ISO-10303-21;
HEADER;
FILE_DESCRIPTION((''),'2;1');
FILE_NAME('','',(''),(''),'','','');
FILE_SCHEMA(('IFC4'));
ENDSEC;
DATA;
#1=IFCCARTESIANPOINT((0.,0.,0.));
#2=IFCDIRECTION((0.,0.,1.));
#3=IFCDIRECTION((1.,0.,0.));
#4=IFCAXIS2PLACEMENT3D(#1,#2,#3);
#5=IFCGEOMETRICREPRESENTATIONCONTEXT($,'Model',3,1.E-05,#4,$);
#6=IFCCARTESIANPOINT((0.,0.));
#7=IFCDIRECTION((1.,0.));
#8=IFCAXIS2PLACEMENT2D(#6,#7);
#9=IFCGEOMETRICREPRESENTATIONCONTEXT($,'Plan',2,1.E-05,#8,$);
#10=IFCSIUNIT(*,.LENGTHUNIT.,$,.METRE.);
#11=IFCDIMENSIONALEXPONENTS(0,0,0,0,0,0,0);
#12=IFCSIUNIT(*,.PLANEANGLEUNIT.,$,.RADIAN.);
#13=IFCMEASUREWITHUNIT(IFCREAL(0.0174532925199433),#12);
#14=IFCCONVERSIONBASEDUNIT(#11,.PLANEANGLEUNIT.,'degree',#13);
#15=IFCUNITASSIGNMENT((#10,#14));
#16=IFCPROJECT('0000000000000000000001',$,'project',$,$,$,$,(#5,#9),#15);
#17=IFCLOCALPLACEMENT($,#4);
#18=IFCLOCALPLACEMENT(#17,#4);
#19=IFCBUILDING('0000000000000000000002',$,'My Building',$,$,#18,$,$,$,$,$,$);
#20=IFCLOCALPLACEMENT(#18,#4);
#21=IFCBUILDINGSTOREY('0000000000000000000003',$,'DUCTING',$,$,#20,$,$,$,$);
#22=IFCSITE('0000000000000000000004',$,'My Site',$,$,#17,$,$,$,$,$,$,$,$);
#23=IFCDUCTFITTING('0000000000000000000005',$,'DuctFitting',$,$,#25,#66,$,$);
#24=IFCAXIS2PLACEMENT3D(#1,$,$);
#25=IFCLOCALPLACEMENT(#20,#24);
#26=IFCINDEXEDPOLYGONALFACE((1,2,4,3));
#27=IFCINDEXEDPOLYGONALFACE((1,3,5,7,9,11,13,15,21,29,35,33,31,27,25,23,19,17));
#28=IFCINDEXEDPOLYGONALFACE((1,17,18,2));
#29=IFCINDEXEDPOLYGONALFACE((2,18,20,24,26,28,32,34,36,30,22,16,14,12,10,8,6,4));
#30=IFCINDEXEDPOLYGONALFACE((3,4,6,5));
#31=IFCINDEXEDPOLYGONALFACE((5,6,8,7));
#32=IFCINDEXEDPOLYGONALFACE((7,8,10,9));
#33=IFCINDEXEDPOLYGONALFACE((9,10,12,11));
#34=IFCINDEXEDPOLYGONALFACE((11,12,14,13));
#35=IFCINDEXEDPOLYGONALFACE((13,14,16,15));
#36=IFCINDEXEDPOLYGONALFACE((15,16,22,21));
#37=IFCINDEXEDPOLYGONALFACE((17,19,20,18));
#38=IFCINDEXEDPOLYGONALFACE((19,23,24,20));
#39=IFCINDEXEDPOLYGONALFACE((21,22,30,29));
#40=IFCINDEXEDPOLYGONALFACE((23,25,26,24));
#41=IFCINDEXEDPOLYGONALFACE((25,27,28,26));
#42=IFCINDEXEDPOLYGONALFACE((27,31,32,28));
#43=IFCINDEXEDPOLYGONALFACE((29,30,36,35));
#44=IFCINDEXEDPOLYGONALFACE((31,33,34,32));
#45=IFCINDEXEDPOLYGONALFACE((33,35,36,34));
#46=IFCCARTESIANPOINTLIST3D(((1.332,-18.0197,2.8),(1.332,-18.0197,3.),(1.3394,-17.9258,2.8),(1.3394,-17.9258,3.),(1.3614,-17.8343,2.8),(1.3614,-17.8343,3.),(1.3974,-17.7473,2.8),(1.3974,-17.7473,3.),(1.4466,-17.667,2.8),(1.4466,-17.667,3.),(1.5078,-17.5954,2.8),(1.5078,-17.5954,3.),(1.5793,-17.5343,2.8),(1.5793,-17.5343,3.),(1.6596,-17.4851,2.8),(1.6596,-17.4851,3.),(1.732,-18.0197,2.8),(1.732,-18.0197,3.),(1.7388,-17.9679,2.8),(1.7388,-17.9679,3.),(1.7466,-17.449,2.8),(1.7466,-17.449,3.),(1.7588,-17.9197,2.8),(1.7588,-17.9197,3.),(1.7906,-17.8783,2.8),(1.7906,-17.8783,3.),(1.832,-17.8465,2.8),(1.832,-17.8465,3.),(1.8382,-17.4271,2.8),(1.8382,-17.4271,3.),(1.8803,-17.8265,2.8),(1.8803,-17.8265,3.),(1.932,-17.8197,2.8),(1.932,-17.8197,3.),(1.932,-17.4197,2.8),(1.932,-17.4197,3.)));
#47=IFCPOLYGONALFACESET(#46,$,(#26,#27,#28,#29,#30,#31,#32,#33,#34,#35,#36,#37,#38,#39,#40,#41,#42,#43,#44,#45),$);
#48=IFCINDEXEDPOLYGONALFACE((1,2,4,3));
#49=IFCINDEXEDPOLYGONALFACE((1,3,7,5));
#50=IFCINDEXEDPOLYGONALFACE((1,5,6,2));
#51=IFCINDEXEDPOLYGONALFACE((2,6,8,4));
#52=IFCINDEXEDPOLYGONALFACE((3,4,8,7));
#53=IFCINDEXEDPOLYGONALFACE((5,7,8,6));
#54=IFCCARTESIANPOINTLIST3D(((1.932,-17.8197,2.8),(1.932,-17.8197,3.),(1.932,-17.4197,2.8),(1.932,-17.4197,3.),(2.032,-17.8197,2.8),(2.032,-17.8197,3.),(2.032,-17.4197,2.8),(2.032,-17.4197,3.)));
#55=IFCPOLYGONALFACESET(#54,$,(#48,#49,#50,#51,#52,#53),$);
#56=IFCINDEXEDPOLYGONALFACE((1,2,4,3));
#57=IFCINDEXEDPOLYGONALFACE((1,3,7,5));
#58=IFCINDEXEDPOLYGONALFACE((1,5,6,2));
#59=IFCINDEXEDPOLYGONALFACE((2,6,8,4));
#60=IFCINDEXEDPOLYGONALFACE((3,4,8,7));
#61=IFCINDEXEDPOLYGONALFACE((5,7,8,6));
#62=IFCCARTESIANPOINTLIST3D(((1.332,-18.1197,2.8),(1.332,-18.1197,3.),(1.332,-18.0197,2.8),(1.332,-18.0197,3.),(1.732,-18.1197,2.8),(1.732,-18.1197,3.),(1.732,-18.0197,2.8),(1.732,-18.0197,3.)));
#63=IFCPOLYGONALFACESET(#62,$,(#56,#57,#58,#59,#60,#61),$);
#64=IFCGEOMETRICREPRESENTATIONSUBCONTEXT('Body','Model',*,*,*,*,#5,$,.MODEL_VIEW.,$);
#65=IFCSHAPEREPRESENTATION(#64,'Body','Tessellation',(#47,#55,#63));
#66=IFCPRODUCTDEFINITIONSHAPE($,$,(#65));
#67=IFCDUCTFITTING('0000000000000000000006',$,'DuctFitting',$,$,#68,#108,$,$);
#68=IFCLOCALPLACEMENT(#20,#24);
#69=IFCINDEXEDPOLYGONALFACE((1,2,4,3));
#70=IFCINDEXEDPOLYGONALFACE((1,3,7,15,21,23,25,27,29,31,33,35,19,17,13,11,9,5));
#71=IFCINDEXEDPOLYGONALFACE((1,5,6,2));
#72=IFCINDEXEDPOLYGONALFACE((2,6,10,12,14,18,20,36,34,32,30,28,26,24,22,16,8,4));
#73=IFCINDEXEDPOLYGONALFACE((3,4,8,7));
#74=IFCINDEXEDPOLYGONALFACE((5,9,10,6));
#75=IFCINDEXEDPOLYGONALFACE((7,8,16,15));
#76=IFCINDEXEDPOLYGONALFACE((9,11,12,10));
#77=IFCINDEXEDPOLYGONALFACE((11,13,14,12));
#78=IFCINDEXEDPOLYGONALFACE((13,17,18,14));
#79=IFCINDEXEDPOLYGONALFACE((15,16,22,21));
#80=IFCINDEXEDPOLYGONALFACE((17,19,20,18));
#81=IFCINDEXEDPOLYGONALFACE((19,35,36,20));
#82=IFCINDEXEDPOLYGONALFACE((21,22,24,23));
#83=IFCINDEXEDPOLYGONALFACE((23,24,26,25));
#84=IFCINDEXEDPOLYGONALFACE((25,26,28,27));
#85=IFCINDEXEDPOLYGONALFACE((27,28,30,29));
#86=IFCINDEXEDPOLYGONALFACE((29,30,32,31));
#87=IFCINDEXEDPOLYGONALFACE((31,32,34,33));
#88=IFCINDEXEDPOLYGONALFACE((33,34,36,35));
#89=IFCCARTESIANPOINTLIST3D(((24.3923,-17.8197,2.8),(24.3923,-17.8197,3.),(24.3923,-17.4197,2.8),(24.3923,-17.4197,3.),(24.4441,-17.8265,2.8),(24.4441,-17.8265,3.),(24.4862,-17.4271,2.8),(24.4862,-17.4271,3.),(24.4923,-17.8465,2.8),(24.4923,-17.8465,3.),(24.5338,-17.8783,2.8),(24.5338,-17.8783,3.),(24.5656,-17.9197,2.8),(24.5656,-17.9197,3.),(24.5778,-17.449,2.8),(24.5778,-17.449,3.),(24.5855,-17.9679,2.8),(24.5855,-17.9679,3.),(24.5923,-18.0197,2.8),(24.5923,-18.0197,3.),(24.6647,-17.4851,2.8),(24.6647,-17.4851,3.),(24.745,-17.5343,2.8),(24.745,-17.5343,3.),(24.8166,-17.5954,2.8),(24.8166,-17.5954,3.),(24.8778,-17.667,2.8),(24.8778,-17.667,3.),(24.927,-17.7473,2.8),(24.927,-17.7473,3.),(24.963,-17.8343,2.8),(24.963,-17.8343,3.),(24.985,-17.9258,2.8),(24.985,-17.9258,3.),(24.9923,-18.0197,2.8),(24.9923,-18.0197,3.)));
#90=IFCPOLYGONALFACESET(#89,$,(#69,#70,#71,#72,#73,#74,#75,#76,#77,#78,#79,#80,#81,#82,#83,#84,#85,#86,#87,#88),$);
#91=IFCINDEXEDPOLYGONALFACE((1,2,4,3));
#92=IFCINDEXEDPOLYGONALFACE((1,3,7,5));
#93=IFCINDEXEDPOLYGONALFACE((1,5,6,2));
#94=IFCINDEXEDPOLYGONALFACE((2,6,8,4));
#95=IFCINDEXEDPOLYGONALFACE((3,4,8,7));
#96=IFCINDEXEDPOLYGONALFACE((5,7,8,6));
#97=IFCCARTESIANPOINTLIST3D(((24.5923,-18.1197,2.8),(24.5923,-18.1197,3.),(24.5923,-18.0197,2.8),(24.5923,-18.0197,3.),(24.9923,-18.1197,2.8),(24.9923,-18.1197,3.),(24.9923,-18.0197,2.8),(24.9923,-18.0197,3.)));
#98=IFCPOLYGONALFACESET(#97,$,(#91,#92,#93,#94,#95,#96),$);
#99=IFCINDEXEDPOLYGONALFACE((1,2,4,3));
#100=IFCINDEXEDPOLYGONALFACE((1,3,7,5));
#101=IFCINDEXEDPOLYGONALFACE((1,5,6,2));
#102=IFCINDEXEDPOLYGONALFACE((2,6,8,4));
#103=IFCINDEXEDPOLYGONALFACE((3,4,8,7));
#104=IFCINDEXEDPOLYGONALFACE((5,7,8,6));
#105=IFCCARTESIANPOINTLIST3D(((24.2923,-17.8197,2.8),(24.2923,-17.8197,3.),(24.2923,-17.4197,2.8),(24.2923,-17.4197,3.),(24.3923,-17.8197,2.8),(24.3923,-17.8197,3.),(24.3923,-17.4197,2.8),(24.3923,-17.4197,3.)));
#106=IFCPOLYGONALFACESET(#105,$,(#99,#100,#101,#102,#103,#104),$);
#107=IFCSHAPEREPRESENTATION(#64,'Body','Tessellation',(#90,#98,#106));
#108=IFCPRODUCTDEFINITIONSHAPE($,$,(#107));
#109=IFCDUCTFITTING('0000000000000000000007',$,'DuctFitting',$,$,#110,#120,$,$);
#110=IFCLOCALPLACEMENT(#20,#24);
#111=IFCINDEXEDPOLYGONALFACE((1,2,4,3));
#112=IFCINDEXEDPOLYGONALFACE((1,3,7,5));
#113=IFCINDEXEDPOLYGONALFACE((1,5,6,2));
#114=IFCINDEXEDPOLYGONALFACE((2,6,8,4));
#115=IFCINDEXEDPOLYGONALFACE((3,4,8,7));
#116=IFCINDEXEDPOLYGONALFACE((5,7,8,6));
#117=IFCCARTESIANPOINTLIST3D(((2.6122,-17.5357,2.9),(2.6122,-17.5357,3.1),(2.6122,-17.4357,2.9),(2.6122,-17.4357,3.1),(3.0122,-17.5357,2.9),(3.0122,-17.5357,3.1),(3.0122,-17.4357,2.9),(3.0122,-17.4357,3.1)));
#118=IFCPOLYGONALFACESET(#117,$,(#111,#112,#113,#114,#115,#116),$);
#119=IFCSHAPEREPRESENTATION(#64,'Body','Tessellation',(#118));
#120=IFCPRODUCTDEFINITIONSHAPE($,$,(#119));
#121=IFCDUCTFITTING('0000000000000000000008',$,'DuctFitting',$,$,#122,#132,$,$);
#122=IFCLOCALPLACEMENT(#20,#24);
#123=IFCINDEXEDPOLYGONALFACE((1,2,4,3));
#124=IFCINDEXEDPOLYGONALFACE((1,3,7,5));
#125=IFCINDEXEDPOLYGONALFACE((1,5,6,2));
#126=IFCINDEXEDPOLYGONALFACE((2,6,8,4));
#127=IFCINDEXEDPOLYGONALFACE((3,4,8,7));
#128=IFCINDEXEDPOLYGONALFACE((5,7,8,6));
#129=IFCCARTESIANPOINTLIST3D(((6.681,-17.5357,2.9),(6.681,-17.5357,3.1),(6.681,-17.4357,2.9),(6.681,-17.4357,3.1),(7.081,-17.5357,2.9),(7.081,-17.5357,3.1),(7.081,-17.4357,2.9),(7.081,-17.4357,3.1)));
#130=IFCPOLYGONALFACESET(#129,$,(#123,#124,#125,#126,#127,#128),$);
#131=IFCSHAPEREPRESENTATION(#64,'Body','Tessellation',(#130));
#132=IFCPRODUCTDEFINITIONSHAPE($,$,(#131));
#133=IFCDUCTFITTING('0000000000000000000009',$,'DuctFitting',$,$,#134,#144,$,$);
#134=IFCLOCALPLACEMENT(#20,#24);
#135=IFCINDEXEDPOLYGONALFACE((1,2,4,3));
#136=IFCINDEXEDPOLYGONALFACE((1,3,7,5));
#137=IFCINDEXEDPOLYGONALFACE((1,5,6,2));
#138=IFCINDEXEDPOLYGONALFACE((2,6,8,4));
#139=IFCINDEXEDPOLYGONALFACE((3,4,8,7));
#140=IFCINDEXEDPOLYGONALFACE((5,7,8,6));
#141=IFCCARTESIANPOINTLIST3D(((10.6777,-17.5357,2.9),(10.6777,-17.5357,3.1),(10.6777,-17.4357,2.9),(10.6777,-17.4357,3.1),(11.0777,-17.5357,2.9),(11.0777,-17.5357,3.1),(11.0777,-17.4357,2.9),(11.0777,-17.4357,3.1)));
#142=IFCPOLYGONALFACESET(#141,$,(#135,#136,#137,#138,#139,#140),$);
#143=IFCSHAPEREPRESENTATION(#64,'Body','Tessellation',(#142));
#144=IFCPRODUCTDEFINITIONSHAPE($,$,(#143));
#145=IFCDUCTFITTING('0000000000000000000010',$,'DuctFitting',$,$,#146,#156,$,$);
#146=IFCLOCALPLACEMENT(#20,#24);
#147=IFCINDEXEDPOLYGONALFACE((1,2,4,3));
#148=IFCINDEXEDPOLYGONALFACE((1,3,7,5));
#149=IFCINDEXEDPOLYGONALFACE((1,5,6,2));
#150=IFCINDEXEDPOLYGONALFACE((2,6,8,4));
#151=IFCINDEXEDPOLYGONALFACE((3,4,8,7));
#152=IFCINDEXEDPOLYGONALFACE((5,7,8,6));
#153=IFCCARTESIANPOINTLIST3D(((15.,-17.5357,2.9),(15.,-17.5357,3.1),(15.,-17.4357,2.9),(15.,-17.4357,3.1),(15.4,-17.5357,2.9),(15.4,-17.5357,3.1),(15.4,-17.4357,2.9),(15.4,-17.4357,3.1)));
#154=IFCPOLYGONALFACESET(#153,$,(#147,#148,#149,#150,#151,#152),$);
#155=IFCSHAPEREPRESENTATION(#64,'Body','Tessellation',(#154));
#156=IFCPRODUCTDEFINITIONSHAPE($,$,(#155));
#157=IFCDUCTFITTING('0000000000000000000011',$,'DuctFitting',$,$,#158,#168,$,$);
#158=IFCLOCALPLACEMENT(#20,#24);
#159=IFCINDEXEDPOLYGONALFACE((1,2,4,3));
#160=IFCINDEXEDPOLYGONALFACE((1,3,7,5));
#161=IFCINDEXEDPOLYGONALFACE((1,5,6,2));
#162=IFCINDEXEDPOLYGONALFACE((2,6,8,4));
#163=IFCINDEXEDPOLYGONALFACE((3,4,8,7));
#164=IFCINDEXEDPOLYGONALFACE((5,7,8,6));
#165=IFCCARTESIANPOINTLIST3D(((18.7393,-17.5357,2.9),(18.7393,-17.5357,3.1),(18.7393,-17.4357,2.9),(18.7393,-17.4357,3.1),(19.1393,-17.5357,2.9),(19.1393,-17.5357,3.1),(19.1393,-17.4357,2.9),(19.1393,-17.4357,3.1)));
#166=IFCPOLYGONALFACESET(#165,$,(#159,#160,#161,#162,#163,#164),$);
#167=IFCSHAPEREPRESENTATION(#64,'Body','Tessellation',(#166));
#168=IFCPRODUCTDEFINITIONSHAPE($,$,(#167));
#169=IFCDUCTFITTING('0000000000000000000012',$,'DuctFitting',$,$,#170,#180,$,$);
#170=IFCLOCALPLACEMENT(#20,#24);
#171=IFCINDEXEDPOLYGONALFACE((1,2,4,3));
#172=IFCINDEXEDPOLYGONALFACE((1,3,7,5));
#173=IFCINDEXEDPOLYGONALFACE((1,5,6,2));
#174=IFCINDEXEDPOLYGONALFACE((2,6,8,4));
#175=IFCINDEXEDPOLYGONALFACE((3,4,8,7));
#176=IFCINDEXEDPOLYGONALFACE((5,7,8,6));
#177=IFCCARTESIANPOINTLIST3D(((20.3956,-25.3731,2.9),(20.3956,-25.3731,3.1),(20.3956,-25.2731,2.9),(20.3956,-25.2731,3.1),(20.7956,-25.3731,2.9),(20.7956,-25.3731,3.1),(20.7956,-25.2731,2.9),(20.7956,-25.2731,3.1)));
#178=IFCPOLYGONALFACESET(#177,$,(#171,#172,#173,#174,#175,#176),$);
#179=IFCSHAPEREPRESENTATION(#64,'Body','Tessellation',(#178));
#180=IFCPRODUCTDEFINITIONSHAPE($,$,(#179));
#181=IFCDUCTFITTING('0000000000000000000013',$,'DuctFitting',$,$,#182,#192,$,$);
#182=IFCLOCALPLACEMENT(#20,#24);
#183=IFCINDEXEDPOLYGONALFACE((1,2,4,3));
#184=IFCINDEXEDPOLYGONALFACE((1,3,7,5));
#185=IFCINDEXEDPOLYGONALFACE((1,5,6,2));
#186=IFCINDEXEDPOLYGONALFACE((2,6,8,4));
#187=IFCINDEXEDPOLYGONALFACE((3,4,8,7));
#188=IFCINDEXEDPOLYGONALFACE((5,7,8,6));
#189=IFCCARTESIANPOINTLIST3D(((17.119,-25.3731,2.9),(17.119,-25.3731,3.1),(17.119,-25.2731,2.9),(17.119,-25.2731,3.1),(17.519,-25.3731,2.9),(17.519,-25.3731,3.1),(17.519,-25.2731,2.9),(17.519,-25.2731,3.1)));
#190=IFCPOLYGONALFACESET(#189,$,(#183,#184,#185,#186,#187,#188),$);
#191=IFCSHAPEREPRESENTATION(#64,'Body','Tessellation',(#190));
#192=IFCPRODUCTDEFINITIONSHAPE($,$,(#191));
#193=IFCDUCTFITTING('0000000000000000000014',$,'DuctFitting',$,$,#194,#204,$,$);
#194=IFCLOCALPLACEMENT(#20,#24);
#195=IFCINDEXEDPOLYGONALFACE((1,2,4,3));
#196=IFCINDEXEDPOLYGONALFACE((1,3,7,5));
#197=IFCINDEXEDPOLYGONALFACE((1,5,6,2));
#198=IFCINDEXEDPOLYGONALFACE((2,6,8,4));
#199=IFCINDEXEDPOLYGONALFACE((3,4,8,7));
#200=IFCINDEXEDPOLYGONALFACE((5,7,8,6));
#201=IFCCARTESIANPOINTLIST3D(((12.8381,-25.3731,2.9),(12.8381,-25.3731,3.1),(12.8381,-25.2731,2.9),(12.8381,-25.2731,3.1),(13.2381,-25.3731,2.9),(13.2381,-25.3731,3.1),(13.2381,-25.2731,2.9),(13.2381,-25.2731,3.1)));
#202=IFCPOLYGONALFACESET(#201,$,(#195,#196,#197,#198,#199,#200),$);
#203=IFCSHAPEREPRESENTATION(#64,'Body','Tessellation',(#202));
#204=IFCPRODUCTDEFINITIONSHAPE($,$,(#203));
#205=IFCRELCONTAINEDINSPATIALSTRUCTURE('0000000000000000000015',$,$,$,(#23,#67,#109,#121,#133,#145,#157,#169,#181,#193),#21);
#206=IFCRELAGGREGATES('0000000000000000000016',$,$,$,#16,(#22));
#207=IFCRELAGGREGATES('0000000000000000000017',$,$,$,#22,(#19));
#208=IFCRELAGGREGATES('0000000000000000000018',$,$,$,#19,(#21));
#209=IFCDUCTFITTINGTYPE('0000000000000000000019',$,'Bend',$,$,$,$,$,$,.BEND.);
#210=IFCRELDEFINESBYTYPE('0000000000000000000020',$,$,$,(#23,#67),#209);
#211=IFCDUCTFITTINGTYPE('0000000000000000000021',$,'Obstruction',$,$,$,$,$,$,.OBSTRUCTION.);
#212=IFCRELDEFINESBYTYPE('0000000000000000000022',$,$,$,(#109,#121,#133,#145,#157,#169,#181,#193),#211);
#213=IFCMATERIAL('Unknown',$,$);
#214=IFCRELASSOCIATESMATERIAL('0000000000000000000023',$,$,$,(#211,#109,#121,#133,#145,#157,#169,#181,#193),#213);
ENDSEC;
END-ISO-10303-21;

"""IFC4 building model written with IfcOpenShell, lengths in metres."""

from ifc_helpers import new_model, entity, si_unit, converted_unit, frame, origin_with_axes, origin_2d_with_axis, place, context, subcontext, project, spatial, line, arc, indexed_curve, rectangle, outline, extrude, source, transform, mapped, material, material_profile, profile_set, profile_usage, type_object, type_shapes, element, save


model = new_model("IFC4")

# Units and contexts
model_context = context("Model", 3, precision=1e-05, world=origin_with_axes())
plan_context = context("Plan", 2, precision=1e-05, world=origin_2d_with_axis())
body_context = subcontext(model_context, "Body", "Model", "MODEL_VIEW")
ifc_project = project(units=[si_unit("LENGTHUNIT", "METRE"), converted_unit("PLANEANGLEUNIT", "degree", entity("IfcReal", 0.0174532925199433), si_unit("PLANEANGLEUNIT", "RADIAN"), dimensions=[0, 0, 0, 0, 0, 0, 0])], contexts=[model_context, plan_context])

# Site, building, storey
site_placement = place(None, origin_with_axes())
site = spatial("IfcSite", under=ifc_project, at=site_placement, Name="My Site")
building_placement = place(site_placement, origin_with_axes())
building = spatial("IfcBuilding", under=site, at=building_placement, Name="My Building")
storey_placement = place(building_placement, origin_with_axes())
storey = spatial("IfcBuildingStorey", under=building, at=storey_placement, Name="DUCTING")

# Shared definitions
ifc_material = material(Name="Unknown")

# Duct fittings
duct_fitting_type_1 = type_object("IfcDuctFittingType", Name="Bend", PredefinedType="BEND")
shared_shape = source(origin_with_axes(), body_context, "Body", "SweptSolid", [
    extrude(outline(indexed_curve([(-0.2, 0.0), (-0.2586, -0.1414), (-0.4, -0.2), (-0.4, -0.6), (0.0243, -0.4243), (0.2, 0.0)], segments=[arc(1, 2, 3), line(3, 4), arc(4, 5, 6), line(6, 1)])), frame((0.0, -0.1, -0.1), z_axis=(0.0, -1.0, 0.0), x_axis=(1.0, 0.0, 0.0)), (0.0, 0.0, -1.0), 0.2),
    extrude(rectangle(XDim=0.4, YDim=0.2), origin_with_axes(), (0.0, 0.0, -1.0), 0.1),
    extrude(rectangle(XDim=0.4, YDim=0.2), frame((-0.4, 0.0, -0.5), z_axis=(-1.0, 0.0, 0.0), x_axis=(0.0, 0.0, -1.0)), (0.0, 0.0, 1.0), 0.1),
])
type_shapes(duct_fitting_type_1, [shared_shape])
for number, where, z_axis, x_axis, name in (
    (1, (2.032, -17.6197, 2.9), (1.0, 0.0, 0.0), (0.0, 1.0, 0.0), "DuctFitting"),
    (2, (24.7923, -18.1197, 2.9), (0.0, -1.0, 0.0), (1.0, 0.0, 0.0), "DuctFitting"),
):
    element("IfcDuctFitting", number, at=place(storey_placement, frame(where, z_axis=z_axis, x_axis=x_axis)), inside=storey, type_object=duct_fitting_type_1, Name=name, context=body_context, shape_type="MappedRepresentation", body=[
        mapped(shared_shape, transform((0.0, 0.0, 0.0), x_axis=(1.0, 0.0, 0.0), y_axis=(0.0, 1.0, 0.0), z_axis=(0.0, 0.0, 1.0), scale=1.0)),
    ])
ifc_material_profile_1 = material_profile(ifc_material, rectangle(XDim=0.4, YDim=0.2))
ifc_profile_set_1 = profile_set([ifc_material_profile_1])
ifc_profile_usage_1 = profile_usage(ifc_profile_set_1, cardinal=5)
duct_fitting_type_2 = type_object("IfcDuctFittingType", Name="Obstruction", PredefinedType="OBSTRUCTION", material=ifc_profile_set_1)
duct_fitting_1_placement = place(storey_placement, frame((2.8122, -17.5357, 3.0), z_axis=(0.0, 1.0, 0.0), x_axis=(-1.0, 0.0, 0.0)))
element("IfcDuctFitting", 3, at=duct_fitting_1_placement, inside=storey, type_object=duct_fitting_type_2, material=ifc_profile_usage_1, Name="DuctFitting", context=body_context, shape_type="SweptSolid", body=[
    extrude(rectangle(XDim=0.4, YDim=0.2), origin_with_axes(), (0.0, 0.0, 1.0), 0.1),
])
ifc_profile_usage_2 = profile_usage(ifc_profile_set_1, cardinal=5)
duct_fitting_2_placement = place(storey_placement, frame((6.881, -17.5357, 3.0), z_axis=(0.0, 1.0, 0.0), x_axis=(-1.0, 0.0, 0.0)))
element("IfcDuctFitting", 4, at=duct_fitting_2_placement, inside=storey, type_object=duct_fitting_type_2, material=ifc_profile_usage_2, Name="DuctFitting", context=body_context, shape_type="SweptSolid", body=[
    extrude(rectangle(XDim=0.4, YDim=0.2), origin_with_axes(), (0.0, 0.0, 1.0), 0.1),
])
ifc_profile_usage_3 = profile_usage(ifc_profile_set_1, cardinal=5)
duct_fitting_3_placement = place(storey_placement, frame((10.8777, -17.5357, 3.0), z_axis=(0.0, 1.0, 0.0), x_axis=(-1.0, 0.0, 0.0)))
element("IfcDuctFitting", 5, at=duct_fitting_3_placement, inside=storey, type_object=duct_fitting_type_2, material=ifc_profile_usage_3, Name="DuctFitting", context=body_context, shape_type="SweptSolid", body=[
    extrude(rectangle(XDim=0.4, YDim=0.2), origin_with_axes(), (0.0, 0.0, 1.0), 0.1),
])
ifc_profile_usage_4 = profile_usage(ifc_profile_set_1, cardinal=5)
duct_fitting_4_placement = place(storey_placement, frame((15.2, -17.5357, 3.0), z_axis=(0.0, 1.0, 0.0), x_axis=(-1.0, 0.0, 0.0)))
element("IfcDuctFitting", 6, at=duct_fitting_4_placement, inside=storey, type_object=duct_fitting_type_2, material=ifc_profile_usage_4, Name="DuctFitting", context=body_context, shape_type="SweptSolid", body=[
    extrude(rectangle(XDim=0.4, YDim=0.2), origin_with_axes(), (0.0, 0.0, 1.0), 0.1),
])
ifc_profile_usage_5 = profile_usage(ifc_profile_set_1, cardinal=5)
duct_fitting_5_placement = place(storey_placement, frame((18.9393, -17.5357, 3.0), z_axis=(0.0, 1.0, 0.0), x_axis=(-1.0, 0.0, 0.0)))
element("IfcDuctFitting", 7, at=duct_fitting_5_placement, inside=storey, type_object=duct_fitting_type_2, material=ifc_profile_usage_5, Name="DuctFitting", context=body_context, shape_type="SweptSolid", body=[
    extrude(rectangle(XDim=0.4, YDim=0.2), origin_with_axes(), (0.0, 0.0, 1.0), 0.1),
])
ifc_profile_usage_6 = profile_usage(ifc_profile_set_1, cardinal=5)
duct_fitting_6_placement = place(storey_placement, frame((20.5956, -25.3731, 3.0), z_axis=(0.0, 1.0, 0.0), x_axis=(-1.0, 0.0, 0.0)))
element("IfcDuctFitting", 8, at=duct_fitting_6_placement, inside=storey, type_object=duct_fitting_type_2, material=ifc_profile_usage_6, Name="DuctFitting", context=body_context, shape_type="SweptSolid", body=[
    extrude(rectangle(XDim=0.4, YDim=0.2), origin_with_axes(), (0.0, 0.0, 1.0), 0.1),
])
ifc_profile_usage_7 = profile_usage(ifc_profile_set_1, cardinal=5)
duct_fitting_7_placement = place(storey_placement, frame((17.319, -25.3731, 3.0), z_axis=(0.0, 1.0, 0.0), x_axis=(-1.0, 0.0, 0.0)))
element("IfcDuctFitting", 9, at=duct_fitting_7_placement, inside=storey, type_object=duct_fitting_type_2, material=ifc_profile_usage_7, Name="DuctFitting", context=body_context, shape_type="SweptSolid", body=[
    extrude(rectangle(XDim=0.4, YDim=0.2), origin_with_axes(), (0.0, 0.0, 1.0), 0.1),
])
ifc_profile_usage_8 = profile_usage(ifc_profile_set_1, cardinal=5)
duct_fitting_8_placement = place(storey_placement, frame((13.0381, -25.3731, 3.0), z_axis=(0.0, 1.0, 0.0), x_axis=(-1.0, 0.0, 0.0)))
element("IfcDuctFitting", 10, at=duct_fitting_8_placement, inside=storey, type_object=duct_fitting_type_2, material=ifc_profile_usage_8, Name="DuctFitting", context=body_context, shape_type="SweptSolid", body=[
    extrude(rectangle(XDim=0.4, YDim=0.2), origin_with_axes(), (0.0, 0.0, 1.0), 0.1),
])

save(model, "model.ifc")
